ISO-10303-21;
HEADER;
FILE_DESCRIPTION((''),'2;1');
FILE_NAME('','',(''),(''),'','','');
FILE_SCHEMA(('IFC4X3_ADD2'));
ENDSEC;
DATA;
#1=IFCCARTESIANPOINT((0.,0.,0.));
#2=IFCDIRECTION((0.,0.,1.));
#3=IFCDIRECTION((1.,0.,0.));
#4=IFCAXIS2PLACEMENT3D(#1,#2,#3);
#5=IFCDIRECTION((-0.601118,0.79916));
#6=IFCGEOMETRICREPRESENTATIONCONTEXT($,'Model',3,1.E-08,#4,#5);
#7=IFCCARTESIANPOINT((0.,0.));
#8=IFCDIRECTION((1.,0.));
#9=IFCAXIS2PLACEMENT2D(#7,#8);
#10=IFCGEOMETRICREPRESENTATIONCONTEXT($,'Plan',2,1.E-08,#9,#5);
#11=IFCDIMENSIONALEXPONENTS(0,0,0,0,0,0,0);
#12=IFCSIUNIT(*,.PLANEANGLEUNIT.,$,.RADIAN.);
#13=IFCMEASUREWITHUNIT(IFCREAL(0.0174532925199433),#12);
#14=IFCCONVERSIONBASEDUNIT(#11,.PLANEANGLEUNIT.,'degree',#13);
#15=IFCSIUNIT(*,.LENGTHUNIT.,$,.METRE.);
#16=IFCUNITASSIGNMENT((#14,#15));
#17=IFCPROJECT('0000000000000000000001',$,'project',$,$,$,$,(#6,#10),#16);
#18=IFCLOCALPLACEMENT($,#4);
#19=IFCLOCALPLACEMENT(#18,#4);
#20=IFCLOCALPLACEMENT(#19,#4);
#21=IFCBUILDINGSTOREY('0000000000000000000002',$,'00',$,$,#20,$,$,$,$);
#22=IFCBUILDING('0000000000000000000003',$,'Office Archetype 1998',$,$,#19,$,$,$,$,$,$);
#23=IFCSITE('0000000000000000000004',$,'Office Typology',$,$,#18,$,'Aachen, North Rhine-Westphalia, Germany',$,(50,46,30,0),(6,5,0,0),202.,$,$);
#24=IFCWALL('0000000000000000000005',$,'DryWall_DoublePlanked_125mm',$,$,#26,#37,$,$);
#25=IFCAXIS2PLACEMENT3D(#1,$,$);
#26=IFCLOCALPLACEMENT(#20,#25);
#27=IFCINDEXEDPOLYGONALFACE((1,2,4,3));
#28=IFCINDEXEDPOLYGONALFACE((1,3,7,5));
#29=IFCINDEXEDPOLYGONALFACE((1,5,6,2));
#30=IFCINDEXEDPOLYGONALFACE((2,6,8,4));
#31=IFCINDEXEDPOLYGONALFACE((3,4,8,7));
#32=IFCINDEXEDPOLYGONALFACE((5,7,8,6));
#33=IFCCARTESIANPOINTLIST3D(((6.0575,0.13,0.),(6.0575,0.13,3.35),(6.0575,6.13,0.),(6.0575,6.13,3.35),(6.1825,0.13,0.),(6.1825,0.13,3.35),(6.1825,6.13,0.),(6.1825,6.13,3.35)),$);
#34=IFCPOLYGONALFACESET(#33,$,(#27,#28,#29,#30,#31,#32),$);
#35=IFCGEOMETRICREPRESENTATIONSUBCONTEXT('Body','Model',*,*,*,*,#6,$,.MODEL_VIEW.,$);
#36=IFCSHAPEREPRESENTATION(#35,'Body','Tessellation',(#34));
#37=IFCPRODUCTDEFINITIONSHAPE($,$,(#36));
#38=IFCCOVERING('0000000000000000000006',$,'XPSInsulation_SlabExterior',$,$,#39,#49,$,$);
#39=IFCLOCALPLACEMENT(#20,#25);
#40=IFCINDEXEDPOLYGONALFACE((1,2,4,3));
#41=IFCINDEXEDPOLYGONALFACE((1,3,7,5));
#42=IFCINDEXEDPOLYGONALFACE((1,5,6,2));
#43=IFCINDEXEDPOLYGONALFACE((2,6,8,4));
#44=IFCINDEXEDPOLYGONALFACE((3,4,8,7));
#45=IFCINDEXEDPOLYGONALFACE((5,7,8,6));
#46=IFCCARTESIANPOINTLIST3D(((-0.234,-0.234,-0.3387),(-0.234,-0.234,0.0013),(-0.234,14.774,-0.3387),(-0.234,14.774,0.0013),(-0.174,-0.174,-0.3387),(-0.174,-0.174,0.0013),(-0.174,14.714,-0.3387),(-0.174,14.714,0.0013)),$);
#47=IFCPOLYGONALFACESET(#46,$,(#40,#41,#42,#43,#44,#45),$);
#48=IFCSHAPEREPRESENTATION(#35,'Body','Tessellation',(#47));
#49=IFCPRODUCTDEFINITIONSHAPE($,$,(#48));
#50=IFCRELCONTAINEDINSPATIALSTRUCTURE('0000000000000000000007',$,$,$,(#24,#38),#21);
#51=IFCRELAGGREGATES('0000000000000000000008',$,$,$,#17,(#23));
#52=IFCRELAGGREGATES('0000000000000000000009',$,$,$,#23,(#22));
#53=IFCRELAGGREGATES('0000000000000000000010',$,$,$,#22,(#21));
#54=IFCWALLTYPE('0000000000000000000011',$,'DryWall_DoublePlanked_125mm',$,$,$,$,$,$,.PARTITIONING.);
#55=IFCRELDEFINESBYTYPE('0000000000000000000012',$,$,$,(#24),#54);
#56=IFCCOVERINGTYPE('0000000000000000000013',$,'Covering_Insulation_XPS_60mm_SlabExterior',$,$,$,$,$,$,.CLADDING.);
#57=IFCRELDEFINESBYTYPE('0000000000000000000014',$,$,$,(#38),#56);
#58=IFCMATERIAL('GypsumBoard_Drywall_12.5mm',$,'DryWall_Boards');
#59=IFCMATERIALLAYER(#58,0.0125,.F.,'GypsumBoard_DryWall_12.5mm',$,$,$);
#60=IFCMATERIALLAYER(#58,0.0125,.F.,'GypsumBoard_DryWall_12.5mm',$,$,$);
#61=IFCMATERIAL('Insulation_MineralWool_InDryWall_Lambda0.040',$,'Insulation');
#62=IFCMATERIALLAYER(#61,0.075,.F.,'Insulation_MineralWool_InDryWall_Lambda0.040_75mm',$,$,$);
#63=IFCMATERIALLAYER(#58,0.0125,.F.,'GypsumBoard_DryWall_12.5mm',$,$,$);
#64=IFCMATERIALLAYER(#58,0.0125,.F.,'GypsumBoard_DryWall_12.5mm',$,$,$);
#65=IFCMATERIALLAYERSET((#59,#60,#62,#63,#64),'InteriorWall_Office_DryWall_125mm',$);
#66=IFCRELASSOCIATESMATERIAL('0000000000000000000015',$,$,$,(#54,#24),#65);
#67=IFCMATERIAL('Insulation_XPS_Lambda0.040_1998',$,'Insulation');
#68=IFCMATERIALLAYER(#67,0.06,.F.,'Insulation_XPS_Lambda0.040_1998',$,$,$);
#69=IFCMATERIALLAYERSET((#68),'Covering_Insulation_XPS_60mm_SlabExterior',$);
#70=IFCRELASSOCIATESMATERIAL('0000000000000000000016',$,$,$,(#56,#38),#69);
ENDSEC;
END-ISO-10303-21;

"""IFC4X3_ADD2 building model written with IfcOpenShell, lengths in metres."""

from ifc_helpers import new_model, entity, si_unit, converted_unit, direction, frame, origin_with_axes, origin_2d_with_axis, place, context, subcontext, project, spatial, line, indexed_curve, outline, extrude, material, layer, layer_set, layer_usage, type_object, element, save


model = new_model("IFC4X3_ADD2")

# Units and contexts
model_context = context("Model", 3, precision=1e-08, world=origin_with_axes(), true_north=direction((-0.601118, 0.79916)))
plan_context = context("Plan", 2, precision=1e-08, world=origin_2d_with_axis(), true_north=direction((-0.601118, 0.79916)))
body_context = subcontext(model_context, "Body", "Model", "MODEL_VIEW")
ifc_project = project(units=[converted_unit("PLANEANGLEUNIT", "degree", entity("IfcReal", 0.0174532925199433), si_unit("PLANEANGLEUNIT", "RADIAN"), dimensions=[0, 0, 0, 0, 0, 0, 0]), si_unit("LENGTHUNIT", "METRE")], contexts=[model_context, plan_context])

# Site, building, storey
site_placement = place(None, origin_with_axes())
site = spatial("IfcSite", under=ifc_project, at=site_placement, Name="Office Typology", LongName="Aachen, North Rhine-Westphalia, Germany", RefLatitude=(50, 46, 30, 0), RefLongitude=(6, 5, 0, 0), RefElevation=202.0)
building_placement = place(site_placement, origin_with_axes())
building = spatial("IfcBuilding", under=site, at=building_placement, Name="Office Archetype 1998")
storey_placement = place(building_placement, origin_with_axes())
storey = spatial("IfcBuildingStorey", under=building, at=storey_placement, Name="00")

# Wall
ifc_material_1 = material(Name="GypsumBoard_Drywall_12.5mm", Category="DryWall_Boards")
ifc_layer_1 = layer(ifc_material_1, 0.0125, ventilated=False, Name="GypsumBoard_DryWall_12.5mm")
ifc_layer_2 = layer(ifc_material_1, 0.0125, ventilated=False, Name="GypsumBoard_DryWall_12.5mm")
ifc_material_2 = material(Name="Insulation_MineralWool_InDryWall_Lambda0.040", Category="Insulation")
ifc_layer_3 = layer(ifc_material_2, 0.075, ventilated=False, Name="Insulation_MineralWool_InDryWall_Lambda0.040_75mm")
ifc_layer_4 = layer(ifc_material_1, 0.0125, ventilated=False, Name="GypsumBoard_DryWall_12.5mm")
ifc_layer_5 = layer(ifc_material_1, 0.0125, ventilated=False, Name="GypsumBoard_DryWall_12.5mm")
ifc_layer_set_1 = layer_set([ifc_layer_1, ifc_layer_2, ifc_layer_3, ifc_layer_4, ifc_layer_5], Name="InteriorWall_Office_DryWall_125mm")
ifc_layer_usage_1 = layer_usage(ifc_layer_set_1, "AXIS2", "POSITIVE", 0.0)
wall_type_1 = type_object("IfcWallType", Name="DryWall_DoublePlanked_125mm", PredefinedType="PARTITIONING", material=ifc_layer_set_1)
wall_1_placement = place(storey_placement, frame((6.0575, 6.13, 0.0), z_axis=(0.0, 0.0, 1.0), x_axis=(0.0, -1.0, 0.0)))
element("IfcWall", 1, at=wall_1_placement, inside=storey, type_object=wall_type_1, material=ifc_layer_usage_1, Name="DryWall_DoublePlanked_125mm", context=body_context, shape_type="SweptSolid", body=[
    extrude(outline(indexed_curve([(0.0, 0.0), (0.0, 0.125), (6.0, 0.125), (6.0, 0.0)], segments=[line(1, 2, 3, 4, 1)])), origin_with_axes(), (0.0, 0.0, 1.0), 3.35),
])

# Covering
ifc_material_3 = material(Name="Insulation_XPS_Lambda0.040_1998", Category="Insulation")
ifc_layer_6 = layer(ifc_material_3, 0.06, ventilated=False, Name="Insulation_XPS_Lambda0.040_1998")
ifc_layer_set_2 = layer_set([ifc_layer_6], Name="Covering_Insulation_XPS_60mm_SlabExterior")
ifc_layer_usage_2 = layer_usage(ifc_layer_set_2, "AXIS2", "POSITIVE", 0.0)
covering_type = type_object("IfcCoveringType", Name="Covering_Insulation_XPS_60mm_SlabExterior", PredefinedType="CLADDING", material=ifc_layer_set_2)
covering_placement = place(storey_placement, frame((-0.234, 14.774, -0.3387), z_axis=(0.0, 0.0, 1.0), x_axis=(0.0, -1.0, 0.0)))
element("IfcCovering", 2, at=covering_placement, inside=storey, type_object=covering_type, material=ifc_layer_usage_2, Name="XPSInsulation_SlabExterior", context=body_context, shape_type="SweptSolid", body=[
    extrude(outline(indexed_curve([(0.0, 0.0), (0.06, 0.06), (14.948, 0.06), (15.008, 0.0)], segments=[line(1, 2, 3, 4, 1)])), origin_with_axes(), (0.0, 0.0, 1.0), 0.34),
])

save(model, "model.ifc")
